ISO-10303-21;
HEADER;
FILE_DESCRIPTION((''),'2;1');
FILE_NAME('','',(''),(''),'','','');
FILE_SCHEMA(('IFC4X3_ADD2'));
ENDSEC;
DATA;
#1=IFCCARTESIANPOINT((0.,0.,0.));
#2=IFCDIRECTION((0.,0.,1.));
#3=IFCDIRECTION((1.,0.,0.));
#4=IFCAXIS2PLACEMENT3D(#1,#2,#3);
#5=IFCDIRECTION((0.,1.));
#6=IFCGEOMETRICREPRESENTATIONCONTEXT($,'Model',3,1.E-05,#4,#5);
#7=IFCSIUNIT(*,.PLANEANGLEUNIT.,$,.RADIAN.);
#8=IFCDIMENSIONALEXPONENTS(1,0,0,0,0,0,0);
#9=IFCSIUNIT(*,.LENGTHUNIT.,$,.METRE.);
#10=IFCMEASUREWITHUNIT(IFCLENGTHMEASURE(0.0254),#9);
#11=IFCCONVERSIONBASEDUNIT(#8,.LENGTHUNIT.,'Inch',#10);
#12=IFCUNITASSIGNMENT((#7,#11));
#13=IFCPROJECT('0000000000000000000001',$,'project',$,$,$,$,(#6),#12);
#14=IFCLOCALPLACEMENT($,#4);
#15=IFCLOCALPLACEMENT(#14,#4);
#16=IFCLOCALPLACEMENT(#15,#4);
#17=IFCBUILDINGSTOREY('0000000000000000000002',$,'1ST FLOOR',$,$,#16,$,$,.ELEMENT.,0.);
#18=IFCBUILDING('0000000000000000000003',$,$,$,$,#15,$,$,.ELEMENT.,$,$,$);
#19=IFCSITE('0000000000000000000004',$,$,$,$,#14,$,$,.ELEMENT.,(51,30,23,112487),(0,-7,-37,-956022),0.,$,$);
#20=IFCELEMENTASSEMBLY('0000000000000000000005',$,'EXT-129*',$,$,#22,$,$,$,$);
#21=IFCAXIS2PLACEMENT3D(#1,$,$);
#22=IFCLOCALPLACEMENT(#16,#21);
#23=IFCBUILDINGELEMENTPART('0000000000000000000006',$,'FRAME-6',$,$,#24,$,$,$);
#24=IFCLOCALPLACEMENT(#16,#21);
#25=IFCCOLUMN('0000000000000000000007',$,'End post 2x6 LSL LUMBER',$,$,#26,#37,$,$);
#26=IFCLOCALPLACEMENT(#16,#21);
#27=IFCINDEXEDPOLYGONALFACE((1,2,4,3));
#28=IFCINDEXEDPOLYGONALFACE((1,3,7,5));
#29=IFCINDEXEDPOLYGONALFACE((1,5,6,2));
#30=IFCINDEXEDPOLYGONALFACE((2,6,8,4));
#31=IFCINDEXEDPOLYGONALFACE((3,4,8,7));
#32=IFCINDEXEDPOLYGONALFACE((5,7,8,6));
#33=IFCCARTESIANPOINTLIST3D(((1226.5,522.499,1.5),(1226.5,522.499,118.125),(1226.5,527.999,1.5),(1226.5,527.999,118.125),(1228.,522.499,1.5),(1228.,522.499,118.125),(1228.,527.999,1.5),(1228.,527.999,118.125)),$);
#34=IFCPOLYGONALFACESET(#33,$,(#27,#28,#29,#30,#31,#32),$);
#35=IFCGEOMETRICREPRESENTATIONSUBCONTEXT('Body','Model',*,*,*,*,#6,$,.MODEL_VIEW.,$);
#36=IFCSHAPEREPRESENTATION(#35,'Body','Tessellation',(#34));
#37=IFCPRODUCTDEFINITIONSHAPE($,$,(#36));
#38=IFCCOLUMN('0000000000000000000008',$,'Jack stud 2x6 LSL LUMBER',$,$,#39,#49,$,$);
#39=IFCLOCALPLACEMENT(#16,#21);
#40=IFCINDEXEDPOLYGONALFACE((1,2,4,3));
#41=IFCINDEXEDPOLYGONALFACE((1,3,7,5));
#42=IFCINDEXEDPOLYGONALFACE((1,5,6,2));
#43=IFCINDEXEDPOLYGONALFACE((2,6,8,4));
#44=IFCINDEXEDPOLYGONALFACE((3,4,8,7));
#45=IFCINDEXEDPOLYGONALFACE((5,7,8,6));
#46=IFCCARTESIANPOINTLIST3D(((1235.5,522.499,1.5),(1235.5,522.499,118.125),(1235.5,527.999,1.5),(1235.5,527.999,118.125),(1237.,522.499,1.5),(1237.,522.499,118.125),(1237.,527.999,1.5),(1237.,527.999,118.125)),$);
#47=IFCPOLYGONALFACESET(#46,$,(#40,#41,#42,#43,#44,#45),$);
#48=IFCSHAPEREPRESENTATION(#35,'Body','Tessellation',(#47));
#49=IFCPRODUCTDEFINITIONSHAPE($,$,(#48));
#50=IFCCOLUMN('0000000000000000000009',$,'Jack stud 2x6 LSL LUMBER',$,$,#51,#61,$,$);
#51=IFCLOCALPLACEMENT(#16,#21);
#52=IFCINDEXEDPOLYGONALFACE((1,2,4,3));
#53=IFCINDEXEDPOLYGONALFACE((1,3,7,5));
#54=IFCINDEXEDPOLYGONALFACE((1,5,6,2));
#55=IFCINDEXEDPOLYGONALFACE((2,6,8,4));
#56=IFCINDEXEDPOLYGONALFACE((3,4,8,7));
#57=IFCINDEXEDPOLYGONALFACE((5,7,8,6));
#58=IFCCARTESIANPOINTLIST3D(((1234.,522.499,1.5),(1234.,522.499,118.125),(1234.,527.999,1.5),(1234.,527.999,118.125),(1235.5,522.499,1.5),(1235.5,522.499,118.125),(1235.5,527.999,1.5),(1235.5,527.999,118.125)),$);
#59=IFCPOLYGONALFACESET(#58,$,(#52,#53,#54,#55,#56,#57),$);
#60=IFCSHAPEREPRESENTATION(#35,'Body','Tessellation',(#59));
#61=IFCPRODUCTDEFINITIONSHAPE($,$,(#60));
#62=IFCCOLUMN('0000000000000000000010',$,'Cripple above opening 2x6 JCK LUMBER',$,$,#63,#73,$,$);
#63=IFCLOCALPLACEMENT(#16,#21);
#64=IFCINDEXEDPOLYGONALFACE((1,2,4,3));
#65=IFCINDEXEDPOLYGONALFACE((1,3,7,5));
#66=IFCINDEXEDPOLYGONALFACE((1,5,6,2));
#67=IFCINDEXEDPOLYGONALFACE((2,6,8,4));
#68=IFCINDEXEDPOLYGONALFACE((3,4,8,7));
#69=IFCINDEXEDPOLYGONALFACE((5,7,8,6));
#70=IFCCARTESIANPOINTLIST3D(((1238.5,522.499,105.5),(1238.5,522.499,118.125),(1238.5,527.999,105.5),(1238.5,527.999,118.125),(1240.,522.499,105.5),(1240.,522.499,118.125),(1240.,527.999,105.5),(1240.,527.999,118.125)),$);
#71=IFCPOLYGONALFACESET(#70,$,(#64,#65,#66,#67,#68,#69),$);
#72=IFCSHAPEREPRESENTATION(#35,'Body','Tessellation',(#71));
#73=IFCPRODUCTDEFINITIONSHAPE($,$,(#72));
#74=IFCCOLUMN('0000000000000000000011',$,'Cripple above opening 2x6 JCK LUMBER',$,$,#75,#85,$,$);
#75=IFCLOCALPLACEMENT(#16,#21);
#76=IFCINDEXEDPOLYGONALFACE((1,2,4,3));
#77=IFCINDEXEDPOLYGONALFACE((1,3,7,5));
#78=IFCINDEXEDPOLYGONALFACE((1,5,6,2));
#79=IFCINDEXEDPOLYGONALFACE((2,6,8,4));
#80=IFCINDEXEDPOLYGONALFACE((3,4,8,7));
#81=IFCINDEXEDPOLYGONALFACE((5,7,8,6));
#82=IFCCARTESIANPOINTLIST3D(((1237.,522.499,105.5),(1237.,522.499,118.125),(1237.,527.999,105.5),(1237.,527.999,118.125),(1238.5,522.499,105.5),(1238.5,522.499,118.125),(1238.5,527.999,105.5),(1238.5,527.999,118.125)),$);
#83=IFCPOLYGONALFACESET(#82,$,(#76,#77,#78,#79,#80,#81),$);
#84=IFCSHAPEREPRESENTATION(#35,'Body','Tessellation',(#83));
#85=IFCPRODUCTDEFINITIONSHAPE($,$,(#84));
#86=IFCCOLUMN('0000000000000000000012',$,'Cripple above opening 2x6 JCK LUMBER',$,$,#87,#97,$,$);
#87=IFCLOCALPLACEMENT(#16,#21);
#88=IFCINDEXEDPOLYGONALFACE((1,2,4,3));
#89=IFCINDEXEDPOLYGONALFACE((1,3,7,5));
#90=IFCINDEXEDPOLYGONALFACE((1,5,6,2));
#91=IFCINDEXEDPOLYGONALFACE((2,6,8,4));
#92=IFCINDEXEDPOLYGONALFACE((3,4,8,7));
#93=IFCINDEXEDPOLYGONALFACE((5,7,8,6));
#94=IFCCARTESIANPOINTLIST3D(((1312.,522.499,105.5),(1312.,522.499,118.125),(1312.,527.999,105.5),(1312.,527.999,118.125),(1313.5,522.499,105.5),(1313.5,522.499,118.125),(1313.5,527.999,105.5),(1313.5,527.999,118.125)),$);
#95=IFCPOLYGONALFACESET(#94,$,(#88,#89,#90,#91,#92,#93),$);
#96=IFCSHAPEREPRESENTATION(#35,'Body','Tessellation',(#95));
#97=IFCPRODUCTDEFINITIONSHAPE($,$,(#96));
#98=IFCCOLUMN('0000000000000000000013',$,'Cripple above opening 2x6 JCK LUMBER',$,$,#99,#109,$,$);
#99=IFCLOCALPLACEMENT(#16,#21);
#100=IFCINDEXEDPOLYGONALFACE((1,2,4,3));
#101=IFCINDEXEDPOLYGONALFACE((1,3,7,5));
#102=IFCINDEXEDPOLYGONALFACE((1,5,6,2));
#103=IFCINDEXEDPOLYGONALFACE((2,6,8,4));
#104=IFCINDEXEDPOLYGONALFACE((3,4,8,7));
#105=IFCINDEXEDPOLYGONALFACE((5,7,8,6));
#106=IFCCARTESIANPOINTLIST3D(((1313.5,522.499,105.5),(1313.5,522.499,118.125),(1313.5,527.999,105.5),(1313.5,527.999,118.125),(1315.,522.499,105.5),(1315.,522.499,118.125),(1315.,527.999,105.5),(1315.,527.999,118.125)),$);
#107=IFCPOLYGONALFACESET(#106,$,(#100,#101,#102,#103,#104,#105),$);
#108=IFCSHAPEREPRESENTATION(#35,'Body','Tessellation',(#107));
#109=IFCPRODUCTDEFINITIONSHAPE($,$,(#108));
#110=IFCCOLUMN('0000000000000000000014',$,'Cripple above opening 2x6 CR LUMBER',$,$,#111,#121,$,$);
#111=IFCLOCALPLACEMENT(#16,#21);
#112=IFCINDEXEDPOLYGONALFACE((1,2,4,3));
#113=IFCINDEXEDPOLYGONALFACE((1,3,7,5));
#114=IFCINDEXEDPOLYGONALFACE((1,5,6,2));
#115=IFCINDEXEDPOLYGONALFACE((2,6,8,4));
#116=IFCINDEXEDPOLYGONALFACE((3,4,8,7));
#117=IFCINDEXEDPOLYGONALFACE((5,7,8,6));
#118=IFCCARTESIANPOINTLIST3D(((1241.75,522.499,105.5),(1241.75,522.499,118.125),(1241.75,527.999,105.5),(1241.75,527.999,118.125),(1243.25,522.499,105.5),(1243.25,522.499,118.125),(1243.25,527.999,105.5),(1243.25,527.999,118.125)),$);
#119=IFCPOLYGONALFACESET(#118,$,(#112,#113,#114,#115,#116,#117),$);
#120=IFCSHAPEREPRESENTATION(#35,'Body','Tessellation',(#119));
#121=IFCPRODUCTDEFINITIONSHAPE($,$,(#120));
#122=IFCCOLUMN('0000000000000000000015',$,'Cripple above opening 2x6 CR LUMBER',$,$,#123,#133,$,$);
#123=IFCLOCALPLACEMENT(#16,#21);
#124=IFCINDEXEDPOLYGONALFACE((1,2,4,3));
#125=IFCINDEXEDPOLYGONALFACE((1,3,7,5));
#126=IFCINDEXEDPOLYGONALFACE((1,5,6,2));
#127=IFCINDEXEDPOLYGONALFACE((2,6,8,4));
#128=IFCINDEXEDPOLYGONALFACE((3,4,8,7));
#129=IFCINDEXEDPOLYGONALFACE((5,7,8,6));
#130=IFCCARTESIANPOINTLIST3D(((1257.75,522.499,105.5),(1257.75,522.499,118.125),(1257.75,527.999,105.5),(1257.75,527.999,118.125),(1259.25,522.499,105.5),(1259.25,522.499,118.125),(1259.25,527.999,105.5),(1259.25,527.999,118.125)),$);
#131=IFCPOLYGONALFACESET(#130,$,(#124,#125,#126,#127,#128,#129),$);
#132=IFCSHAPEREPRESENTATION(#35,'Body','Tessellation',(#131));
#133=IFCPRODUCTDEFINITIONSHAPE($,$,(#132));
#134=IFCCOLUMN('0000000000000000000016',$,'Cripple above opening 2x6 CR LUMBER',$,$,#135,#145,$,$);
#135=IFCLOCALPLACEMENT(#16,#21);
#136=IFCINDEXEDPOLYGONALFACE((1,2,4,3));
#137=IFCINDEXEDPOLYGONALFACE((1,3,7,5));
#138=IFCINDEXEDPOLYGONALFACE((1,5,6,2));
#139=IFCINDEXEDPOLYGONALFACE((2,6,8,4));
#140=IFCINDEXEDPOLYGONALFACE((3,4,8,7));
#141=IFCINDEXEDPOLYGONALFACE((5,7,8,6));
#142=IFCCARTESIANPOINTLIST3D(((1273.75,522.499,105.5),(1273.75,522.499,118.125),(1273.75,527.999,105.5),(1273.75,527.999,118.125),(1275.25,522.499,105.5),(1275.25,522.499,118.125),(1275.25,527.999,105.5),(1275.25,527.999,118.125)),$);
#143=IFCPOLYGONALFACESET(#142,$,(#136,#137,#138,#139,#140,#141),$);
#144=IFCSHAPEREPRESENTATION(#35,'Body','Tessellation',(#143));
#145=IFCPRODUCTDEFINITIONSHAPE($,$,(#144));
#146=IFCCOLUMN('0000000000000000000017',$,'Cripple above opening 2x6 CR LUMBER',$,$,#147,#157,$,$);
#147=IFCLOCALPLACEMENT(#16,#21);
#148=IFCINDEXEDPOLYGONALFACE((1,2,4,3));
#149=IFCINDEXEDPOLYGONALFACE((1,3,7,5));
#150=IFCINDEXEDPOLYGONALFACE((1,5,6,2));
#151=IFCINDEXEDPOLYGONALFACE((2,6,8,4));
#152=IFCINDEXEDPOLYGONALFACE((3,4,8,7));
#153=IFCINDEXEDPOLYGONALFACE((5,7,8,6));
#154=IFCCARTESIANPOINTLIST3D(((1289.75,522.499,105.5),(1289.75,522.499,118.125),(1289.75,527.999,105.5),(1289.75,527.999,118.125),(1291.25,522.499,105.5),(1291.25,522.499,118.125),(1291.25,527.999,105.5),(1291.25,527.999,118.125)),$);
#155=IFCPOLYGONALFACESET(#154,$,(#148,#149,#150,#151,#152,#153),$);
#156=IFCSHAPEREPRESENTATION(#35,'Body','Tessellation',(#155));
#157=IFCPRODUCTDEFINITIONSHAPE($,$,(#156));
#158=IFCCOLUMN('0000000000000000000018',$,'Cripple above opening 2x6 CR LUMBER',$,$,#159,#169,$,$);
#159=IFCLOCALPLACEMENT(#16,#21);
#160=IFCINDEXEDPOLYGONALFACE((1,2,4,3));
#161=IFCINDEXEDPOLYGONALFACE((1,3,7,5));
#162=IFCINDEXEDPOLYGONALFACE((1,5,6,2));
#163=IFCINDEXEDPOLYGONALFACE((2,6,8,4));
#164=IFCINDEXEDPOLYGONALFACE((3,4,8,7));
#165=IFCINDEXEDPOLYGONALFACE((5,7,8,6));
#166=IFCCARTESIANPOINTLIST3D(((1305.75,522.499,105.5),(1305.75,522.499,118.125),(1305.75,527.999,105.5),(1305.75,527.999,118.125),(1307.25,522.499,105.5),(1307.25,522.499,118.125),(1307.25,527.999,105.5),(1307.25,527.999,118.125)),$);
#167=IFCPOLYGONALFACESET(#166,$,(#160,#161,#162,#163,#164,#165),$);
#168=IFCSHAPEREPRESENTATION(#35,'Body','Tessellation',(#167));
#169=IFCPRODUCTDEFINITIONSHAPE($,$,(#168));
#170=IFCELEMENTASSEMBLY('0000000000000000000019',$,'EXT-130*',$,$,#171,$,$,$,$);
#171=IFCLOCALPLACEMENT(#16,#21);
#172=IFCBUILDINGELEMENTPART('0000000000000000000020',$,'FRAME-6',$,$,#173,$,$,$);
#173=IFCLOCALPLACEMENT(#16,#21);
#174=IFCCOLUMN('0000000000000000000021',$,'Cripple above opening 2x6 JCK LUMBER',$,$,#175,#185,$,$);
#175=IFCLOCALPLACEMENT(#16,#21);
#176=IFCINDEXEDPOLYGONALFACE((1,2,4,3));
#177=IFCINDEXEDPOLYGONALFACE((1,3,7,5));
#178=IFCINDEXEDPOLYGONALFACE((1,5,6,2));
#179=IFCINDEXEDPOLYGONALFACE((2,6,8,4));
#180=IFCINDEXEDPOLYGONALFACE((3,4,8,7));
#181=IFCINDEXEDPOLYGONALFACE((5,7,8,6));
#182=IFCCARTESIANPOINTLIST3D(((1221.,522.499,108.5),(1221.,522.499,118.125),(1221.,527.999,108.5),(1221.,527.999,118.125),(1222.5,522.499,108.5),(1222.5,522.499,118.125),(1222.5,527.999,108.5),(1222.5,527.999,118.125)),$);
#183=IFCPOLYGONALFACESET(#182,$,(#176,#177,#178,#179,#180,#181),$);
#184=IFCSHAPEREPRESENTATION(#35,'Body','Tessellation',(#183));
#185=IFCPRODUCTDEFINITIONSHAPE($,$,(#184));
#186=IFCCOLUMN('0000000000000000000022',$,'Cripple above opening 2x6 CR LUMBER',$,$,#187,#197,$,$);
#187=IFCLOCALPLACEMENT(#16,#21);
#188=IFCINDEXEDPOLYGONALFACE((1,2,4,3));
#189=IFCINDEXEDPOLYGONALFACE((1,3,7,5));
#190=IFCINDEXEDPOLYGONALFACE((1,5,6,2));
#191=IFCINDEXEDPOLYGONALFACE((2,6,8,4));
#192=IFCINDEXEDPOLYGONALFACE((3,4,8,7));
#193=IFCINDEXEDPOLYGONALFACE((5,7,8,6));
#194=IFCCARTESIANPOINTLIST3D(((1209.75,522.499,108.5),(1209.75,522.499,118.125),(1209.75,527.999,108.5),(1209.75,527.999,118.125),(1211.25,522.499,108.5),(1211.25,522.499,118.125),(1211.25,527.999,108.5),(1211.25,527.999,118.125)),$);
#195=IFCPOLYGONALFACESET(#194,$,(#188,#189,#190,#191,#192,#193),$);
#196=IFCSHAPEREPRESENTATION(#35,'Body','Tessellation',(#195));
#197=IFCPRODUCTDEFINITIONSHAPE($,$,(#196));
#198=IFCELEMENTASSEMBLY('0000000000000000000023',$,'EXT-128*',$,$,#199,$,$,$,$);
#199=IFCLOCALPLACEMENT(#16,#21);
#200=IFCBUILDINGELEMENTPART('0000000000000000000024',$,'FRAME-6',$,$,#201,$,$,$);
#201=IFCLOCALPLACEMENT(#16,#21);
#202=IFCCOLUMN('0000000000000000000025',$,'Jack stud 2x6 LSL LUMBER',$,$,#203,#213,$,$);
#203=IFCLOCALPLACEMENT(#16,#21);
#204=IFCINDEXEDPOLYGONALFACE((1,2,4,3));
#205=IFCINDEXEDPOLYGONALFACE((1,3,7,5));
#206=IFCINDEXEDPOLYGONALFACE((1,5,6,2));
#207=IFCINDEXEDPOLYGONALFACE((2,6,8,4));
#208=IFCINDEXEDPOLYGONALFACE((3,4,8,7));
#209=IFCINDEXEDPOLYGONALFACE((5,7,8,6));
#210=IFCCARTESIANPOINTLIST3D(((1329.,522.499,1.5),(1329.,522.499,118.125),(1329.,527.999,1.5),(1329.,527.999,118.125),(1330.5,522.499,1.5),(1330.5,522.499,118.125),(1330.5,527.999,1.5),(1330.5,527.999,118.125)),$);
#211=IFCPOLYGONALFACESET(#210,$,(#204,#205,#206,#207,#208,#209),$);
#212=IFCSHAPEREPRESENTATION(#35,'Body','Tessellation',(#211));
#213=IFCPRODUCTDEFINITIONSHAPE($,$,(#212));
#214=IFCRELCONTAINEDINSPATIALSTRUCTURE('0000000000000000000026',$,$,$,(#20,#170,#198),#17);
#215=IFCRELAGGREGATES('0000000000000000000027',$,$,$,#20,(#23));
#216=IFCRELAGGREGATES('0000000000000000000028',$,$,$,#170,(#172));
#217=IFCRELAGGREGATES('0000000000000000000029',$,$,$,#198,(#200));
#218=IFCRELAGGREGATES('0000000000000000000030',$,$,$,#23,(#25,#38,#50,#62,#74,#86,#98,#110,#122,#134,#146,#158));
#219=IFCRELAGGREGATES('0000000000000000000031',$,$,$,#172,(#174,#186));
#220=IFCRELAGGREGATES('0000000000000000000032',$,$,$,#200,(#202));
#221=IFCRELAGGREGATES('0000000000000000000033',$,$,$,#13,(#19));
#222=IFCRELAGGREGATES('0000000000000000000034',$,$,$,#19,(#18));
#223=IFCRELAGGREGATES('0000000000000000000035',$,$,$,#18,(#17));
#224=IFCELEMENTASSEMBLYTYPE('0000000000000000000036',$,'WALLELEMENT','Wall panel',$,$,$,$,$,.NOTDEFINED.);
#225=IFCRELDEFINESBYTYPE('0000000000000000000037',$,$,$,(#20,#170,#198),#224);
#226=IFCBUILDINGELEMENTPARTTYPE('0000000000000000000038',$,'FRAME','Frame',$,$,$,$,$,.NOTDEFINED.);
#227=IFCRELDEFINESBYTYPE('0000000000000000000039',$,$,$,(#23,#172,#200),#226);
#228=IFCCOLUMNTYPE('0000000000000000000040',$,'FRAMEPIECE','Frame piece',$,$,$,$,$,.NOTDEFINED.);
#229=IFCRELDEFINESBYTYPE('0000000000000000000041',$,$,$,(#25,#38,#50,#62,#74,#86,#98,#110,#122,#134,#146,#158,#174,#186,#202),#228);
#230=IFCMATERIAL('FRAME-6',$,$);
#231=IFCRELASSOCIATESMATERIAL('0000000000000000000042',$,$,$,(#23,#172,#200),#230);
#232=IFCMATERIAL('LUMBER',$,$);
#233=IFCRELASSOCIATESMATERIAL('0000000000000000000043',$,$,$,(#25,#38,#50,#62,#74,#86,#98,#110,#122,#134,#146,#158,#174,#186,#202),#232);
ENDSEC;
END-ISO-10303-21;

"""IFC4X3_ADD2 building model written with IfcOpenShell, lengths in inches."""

from ifc_helpers import new_model, entity, si_unit, converted_unit, direction, frame, origin_with_axes, origin_2d_with_axis, place, context, subcontext, project, spatial, rectangle, extrude, material, type_object, element, aggregate, save


model = new_model("IFC4X3_ADD2")

# Units and contexts
model_context = context("Model", 3, precision=1e-05, world=origin_with_axes(), true_north=direction((0.0, 1.0)))
body_context = subcontext(model_context, "Body", "Model", "MODEL_VIEW")
ifc_project = project(units=[si_unit("PLANEANGLEUNIT", "RADIAN"), converted_unit("LENGTHUNIT", "Inch", entity("IfcLengthMeasure", 0.0254), si_unit("LENGTHUNIT", "METRE"), dimensions=[1, 0, 0, 0, 0, 0, 0])], contexts=[model_context])

# Site, building, storey
site_placement = place(None, origin_with_axes())
site = spatial("IfcSite", under=ifc_project, at=site_placement, CompositionType="ELEMENT", RefLatitude=(51, 30, 23, 112487), RefLongitude=(0, -7, -37, -956022), RefElevation=0.0)
building_placement = place(site_placement, origin_with_axes())
building = spatial("IfcBuilding", under=site, at=building_placement, CompositionType="ELEMENT")
storey_placement = place(building_placement, origin_with_axes())
storey = spatial("IfcBuildingStorey", under=building, at=storey_placement, Name="1ST FLOOR", CompositionType="ELEMENT", Elevation=0.0)

# Element assemblies, building element parts, columns
element_assembly_type = type_object("IfcElementAssemblyType", Name="WALLELEMENT", Description="Wall panel", PredefinedType="NOTDEFINED")
assembly_1_placement = place(storey_placement, origin_with_axes())
assembly_1 = element("IfcElementAssembly", 1, at=assembly_1_placement, inside=storey, type_object=element_assembly_type, Name="EXT-129*")
ifc_material_1 = material(Name="FRAME-6")
building_element_part_type = type_object("IfcBuildingElementPartType", Name="FRAME", Description="Frame", PredefinedType="NOTDEFINED")
building_element_part_1_placement = place(storey_placement, origin_with_axes())
building_element_part_1 = element("IfcBuildingElementPart", 2, at=building_element_part_1_placement, type_object=building_element_part_type, material=ifc_material_1, Name="FRAME-6")
aggregate(assembly_1, [building_element_part_1])
ifc_material_2 = material(Name="LUMBER")
column_type = type_object("IfcColumnType", Name="FRAMEPIECE", Description="Frame piece", PredefinedType="NOTDEFINED")
column_1_placement = place(storey_placement, frame((1227.25, 525.249, 118.125), z_axis=(0.0, 0.0, -1.0), x_axis=(1.0, 0.0, 0.0)))
column_1 = element("IfcColumn", 3, at=column_1_placement, type_object=column_type, material=ifc_material_2, Name="End post 2x6 LSL LUMBER", context=body_context, shape_type="SweptSolid", body=[
    extrude(rectangle(XDim=1.5, YDim=5.5, at=origin_2d_with_axis()), origin_with_axes(), (0.0, 0.0, 1.0), 116.625),
])
column_2_placement = place(storey_placement, frame((1236.25, 525.249, 118.125), z_axis=(0.0, 0.0, -1.0), x_axis=(1.0, 0.0, 0.0)))
column_2 = element("IfcColumn", 4, at=column_2_placement, type_object=column_type, material=ifc_material_2, Name="Jack stud 2x6 LSL LUMBER", context=body_context, shape_type="SweptSolid", body=[
    extrude(rectangle(XDim=1.5, YDim=5.5, at=origin_2d_with_axis()), origin_with_axes(), (0.0, 0.0, 1.0), 116.625),
])
column_3_placement = place(storey_placement, frame((1234.75, 525.249, 118.125), z_axis=(0.0, 0.0, -1.0), x_axis=(1.0, 0.0, 0.0)))
column_3 = element("IfcColumn", 5, at=column_3_placement, type_object=column_type, material=ifc_material_2, Name="Jack stud 2x6 LSL LUMBER", context=body_context, shape_type="SweptSolid", body=[
    extrude(rectangle(XDim=1.5, YDim=5.5, at=origin_2d_with_axis()), origin_with_axes(), (0.0, 0.0, 1.0), 116.625),
])
column_4_placement = place(storey_placement, frame((1239.25, 525.249, 118.125), z_axis=(0.0, 0.0, -1.0), x_axis=(1.0, 0.0, 0.0)))
column_4 = element("IfcColumn", 6, at=column_4_placement, type_object=column_type, material=ifc_material_2, Name="Cripple above opening 2x6 JCK LUMBER", context=body_context, shape_type="SweptSolid", body=[
    extrude(rectangle(XDim=1.5, YDim=5.5, at=origin_2d_with_axis()), origin_with_axes(), (0.0, 0.0, 1.0), 12.625),
])
column_5_placement = place(storey_placement, frame((1237.75, 525.249, 118.125), z_axis=(0.0, 0.0, -1.0), x_axis=(1.0, 0.0, 0.0)))
column_5 = element("IfcColumn", 7, at=column_5_placement, type_object=column_type, material=ifc_material_2, Name="Cripple above opening 2x6 JCK LUMBER", context=body_context, shape_type="SweptSolid", body=[
    extrude(rectangle(XDim=1.5, YDim=5.5, at=origin_2d_with_axis()), origin_with_axes(), (0.0, 0.0, 1.0), 12.625),
])
column_6_placement = place(storey_placement, frame((1312.75, 525.249, 105.5), z_axis=(0.0, 0.0, 1.0), x_axis=(-1.0, 0.0, 0.0)))
column_6 = element("IfcColumn", 8, at=column_6_placement, type_object=column_type, material=ifc_material_2, Name="Cripple above opening 2x6 JCK LUMBER", context=body_context, shape_type="SweptSolid", body=[
    extrude(rectangle(XDim=1.5, YDim=5.5, at=origin_2d_with_axis()), origin_with_axes(), (0.0, 0.0, 1.0), 12.625),
])
column_7_placement = place(storey_placement, frame((1314.25, 525.249, 105.5), z_axis=(0.0, 0.0, 1.0), x_axis=(-1.0, 0.0, 0.0)))
column_7 = element("IfcColumn", 9, at=column_7_placement, type_object=column_type, material=ifc_material_2, Name="Cripple above opening 2x6 JCK LUMBER", context=body_context, shape_type="SweptSolid", body=[
    extrude(rectangle(XDim=1.5, YDim=5.5, at=origin_2d_with_axis()), origin_with_axes(), (0.0, 0.0, 1.0), 12.625),
])
column_8_placement = place(storey_placement, frame((1242.5, 525.249, 118.125), z_axis=(0.0, 0.0, -1.0), x_axis=(1.0, 0.0, 0.0)))
column_8 = element("IfcColumn", 10, at=column_8_placement, type_object=column_type, material=ifc_material_2, Name="Cripple above opening 2x6 CR LUMBER", context=body_context, shape_type="SweptSolid", body=[
    extrude(rectangle(XDim=1.5, YDim=5.5, at=origin_2d_with_axis()), origin_with_axes(), (0.0, 0.0, 1.0), 12.625),
])
column_9_placement = place(storey_placement, frame((1258.5, 525.249, 118.125), z_axis=(0.0, 0.0, -1.0), x_axis=(1.0, 0.0, 0.0)))
column_9 = element("IfcColumn", 11, at=column_9_placement, type_object=column_type, material=ifc_material_2, Name="Cripple above opening 2x6 CR LUMBER", context=body_context, shape_type="SweptSolid", body=[
    extrude(rectangle(XDim=1.5, YDim=5.5, at=origin_2d_with_axis()), origin_with_axes(), (0.0, 0.0, 1.0), 12.625),
])
column_10_placement = place(storey_placement, frame((1274.5, 525.249, 118.125), z_axis=(0.0, 0.0, -1.0), x_axis=(1.0, 0.0, 0.0)))
column_10 = element("IfcColumn", 12, at=column_10_placement, type_object=column_type, material=ifc_material_2, Name="Cripple above opening 2x6 CR LUMBER", context=body_context, shape_type="SweptSolid", body=[
    extrude(rectangle(XDim=1.5, YDim=5.5, at=origin_2d_with_axis()), origin_with_axes(), (0.0, 0.0, 1.0), 12.625),
])
column_11_placement = place(storey_placement, frame((1290.5, 525.249, 118.125), z_axis=(0.0, 0.0, -1.0), x_axis=(1.0, 0.0, 0.0)))
column_11 = element("IfcColumn", 13, at=column_11_placement, type_object=column_type, material=ifc_material_2, Name="Cripple above opening 2x6 CR LUMBER", context=body_context, shape_type="SweptSolid", body=[
    extrude(rectangle(XDim=1.5, YDim=5.5, at=origin_2d_with_axis()), origin_with_axes(), (0.0, 0.0, 1.0), 12.625),
])
column_12_placement = place(storey_placement, frame((1306.5, 525.249, 118.125), z_axis=(0.0, 0.0, -1.0), x_axis=(1.0, 0.0, 0.0)))
column_12 = element("IfcColumn", 14, at=column_12_placement, type_object=column_type, material=ifc_material_2, Name="Cripple above opening 2x6 CR LUMBER", context=body_context, shape_type="SweptSolid", body=[
    extrude(rectangle(XDim=1.5, YDim=5.5, at=origin_2d_with_axis()), origin_with_axes(), (0.0, 0.0, 1.0), 12.625),
])
assembly_2_placement = place(storey_placement, origin_with_axes())
assembly_2 = element("IfcElementAssembly", 15, at=assembly_2_placement, inside=storey, type_object=element_assembly_type, Name="EXT-130*")
building_element_part_2_placement = place(storey_placement, origin_with_axes())
building_element_part_2 = element("IfcBuildingElementPart", 16, at=building_element_part_2_placement, type_object=building_element_part_type, material=ifc_material_1, Name="FRAME-6")
aggregate(assembly_2, [building_element_part_2])
column_13_placement = place(storey_placement, frame((1221.75, 525.249, 108.5), z_axis=(0.0, 0.0, 1.0), x_axis=(-1.0, 0.0, 0.0)))
column_13 = element("IfcColumn", 17, at=column_13_placement, type_object=column_type, material=ifc_material_2, Name="Cripple above opening 2x6 JCK LUMBER", context=body_context, shape_type="SweptSolid", body=[
    extrude(rectangle(XDim=1.5, YDim=5.5, at=origin_2d_with_axis()), origin_with_axes(), (0.0, 0.0, 1.0), 9.625),
])
column_14_placement = place(storey_placement, frame((1210.5, 525.249, 118.125), z_axis=(0.0, 0.0, -1.0), x_axis=(1.0, 0.0, 0.0)))
column_14 = element("IfcColumn", 18, at=column_14_placement, type_object=column_type, material=ifc_material_2, Name="Cripple above opening 2x6 CR LUMBER", context=body_context, shape_type="SweptSolid", body=[
    extrude(rectangle(XDim=1.5, YDim=5.5, at=origin_2d_with_axis()), origin_with_axes(), (0.0, 0.0, 1.0), 9.625),
])
assembly_3_placement = place(storey_placement, origin_with_axes())
assembly_3 = element("IfcElementAssembly", 19, at=assembly_3_placement, inside=storey, type_object=element_assembly_type, Name="EXT-128*")
building_element_part_3_placement = place(storey_placement, origin_with_axes())
building_element_part_3 = element("IfcBuildingElementPart", 20, at=building_element_part_3_placement, type_object=building_element_part_type, material=ifc_material_1, Name="FRAME-6")
aggregate(assembly_3, [building_element_part_3])
column_15_placement = place(storey_placement, frame((1329.75, 525.249, 118.125), z_axis=(0.0, 0.0, -1.0), x_axis=(1.0, 0.0, 0.0)))
column_15 = element("IfcColumn", 21, at=column_15_placement, type_object=column_type, material=ifc_material_2, Name="Jack stud 2x6 LSL LUMBER", context=body_context, shape_type="SweptSolid", body=[
    extrude(rectangle(XDim=1.5, YDim=5.5, at=origin_2d_with_axis()), origin_with_axes(), (0.0, 0.0, 1.0), 116.625),
])

aggregate(building_element_part_1, [column_1, column_2, column_3, column_4, column_5, column_6, column_7, column_8, column_9, column_10, column_11, column_12])
aggregate(building_element_part_2, [column_13, column_14])
aggregate(building_element_part_3, [column_15])

save(model, "model.ifc")
